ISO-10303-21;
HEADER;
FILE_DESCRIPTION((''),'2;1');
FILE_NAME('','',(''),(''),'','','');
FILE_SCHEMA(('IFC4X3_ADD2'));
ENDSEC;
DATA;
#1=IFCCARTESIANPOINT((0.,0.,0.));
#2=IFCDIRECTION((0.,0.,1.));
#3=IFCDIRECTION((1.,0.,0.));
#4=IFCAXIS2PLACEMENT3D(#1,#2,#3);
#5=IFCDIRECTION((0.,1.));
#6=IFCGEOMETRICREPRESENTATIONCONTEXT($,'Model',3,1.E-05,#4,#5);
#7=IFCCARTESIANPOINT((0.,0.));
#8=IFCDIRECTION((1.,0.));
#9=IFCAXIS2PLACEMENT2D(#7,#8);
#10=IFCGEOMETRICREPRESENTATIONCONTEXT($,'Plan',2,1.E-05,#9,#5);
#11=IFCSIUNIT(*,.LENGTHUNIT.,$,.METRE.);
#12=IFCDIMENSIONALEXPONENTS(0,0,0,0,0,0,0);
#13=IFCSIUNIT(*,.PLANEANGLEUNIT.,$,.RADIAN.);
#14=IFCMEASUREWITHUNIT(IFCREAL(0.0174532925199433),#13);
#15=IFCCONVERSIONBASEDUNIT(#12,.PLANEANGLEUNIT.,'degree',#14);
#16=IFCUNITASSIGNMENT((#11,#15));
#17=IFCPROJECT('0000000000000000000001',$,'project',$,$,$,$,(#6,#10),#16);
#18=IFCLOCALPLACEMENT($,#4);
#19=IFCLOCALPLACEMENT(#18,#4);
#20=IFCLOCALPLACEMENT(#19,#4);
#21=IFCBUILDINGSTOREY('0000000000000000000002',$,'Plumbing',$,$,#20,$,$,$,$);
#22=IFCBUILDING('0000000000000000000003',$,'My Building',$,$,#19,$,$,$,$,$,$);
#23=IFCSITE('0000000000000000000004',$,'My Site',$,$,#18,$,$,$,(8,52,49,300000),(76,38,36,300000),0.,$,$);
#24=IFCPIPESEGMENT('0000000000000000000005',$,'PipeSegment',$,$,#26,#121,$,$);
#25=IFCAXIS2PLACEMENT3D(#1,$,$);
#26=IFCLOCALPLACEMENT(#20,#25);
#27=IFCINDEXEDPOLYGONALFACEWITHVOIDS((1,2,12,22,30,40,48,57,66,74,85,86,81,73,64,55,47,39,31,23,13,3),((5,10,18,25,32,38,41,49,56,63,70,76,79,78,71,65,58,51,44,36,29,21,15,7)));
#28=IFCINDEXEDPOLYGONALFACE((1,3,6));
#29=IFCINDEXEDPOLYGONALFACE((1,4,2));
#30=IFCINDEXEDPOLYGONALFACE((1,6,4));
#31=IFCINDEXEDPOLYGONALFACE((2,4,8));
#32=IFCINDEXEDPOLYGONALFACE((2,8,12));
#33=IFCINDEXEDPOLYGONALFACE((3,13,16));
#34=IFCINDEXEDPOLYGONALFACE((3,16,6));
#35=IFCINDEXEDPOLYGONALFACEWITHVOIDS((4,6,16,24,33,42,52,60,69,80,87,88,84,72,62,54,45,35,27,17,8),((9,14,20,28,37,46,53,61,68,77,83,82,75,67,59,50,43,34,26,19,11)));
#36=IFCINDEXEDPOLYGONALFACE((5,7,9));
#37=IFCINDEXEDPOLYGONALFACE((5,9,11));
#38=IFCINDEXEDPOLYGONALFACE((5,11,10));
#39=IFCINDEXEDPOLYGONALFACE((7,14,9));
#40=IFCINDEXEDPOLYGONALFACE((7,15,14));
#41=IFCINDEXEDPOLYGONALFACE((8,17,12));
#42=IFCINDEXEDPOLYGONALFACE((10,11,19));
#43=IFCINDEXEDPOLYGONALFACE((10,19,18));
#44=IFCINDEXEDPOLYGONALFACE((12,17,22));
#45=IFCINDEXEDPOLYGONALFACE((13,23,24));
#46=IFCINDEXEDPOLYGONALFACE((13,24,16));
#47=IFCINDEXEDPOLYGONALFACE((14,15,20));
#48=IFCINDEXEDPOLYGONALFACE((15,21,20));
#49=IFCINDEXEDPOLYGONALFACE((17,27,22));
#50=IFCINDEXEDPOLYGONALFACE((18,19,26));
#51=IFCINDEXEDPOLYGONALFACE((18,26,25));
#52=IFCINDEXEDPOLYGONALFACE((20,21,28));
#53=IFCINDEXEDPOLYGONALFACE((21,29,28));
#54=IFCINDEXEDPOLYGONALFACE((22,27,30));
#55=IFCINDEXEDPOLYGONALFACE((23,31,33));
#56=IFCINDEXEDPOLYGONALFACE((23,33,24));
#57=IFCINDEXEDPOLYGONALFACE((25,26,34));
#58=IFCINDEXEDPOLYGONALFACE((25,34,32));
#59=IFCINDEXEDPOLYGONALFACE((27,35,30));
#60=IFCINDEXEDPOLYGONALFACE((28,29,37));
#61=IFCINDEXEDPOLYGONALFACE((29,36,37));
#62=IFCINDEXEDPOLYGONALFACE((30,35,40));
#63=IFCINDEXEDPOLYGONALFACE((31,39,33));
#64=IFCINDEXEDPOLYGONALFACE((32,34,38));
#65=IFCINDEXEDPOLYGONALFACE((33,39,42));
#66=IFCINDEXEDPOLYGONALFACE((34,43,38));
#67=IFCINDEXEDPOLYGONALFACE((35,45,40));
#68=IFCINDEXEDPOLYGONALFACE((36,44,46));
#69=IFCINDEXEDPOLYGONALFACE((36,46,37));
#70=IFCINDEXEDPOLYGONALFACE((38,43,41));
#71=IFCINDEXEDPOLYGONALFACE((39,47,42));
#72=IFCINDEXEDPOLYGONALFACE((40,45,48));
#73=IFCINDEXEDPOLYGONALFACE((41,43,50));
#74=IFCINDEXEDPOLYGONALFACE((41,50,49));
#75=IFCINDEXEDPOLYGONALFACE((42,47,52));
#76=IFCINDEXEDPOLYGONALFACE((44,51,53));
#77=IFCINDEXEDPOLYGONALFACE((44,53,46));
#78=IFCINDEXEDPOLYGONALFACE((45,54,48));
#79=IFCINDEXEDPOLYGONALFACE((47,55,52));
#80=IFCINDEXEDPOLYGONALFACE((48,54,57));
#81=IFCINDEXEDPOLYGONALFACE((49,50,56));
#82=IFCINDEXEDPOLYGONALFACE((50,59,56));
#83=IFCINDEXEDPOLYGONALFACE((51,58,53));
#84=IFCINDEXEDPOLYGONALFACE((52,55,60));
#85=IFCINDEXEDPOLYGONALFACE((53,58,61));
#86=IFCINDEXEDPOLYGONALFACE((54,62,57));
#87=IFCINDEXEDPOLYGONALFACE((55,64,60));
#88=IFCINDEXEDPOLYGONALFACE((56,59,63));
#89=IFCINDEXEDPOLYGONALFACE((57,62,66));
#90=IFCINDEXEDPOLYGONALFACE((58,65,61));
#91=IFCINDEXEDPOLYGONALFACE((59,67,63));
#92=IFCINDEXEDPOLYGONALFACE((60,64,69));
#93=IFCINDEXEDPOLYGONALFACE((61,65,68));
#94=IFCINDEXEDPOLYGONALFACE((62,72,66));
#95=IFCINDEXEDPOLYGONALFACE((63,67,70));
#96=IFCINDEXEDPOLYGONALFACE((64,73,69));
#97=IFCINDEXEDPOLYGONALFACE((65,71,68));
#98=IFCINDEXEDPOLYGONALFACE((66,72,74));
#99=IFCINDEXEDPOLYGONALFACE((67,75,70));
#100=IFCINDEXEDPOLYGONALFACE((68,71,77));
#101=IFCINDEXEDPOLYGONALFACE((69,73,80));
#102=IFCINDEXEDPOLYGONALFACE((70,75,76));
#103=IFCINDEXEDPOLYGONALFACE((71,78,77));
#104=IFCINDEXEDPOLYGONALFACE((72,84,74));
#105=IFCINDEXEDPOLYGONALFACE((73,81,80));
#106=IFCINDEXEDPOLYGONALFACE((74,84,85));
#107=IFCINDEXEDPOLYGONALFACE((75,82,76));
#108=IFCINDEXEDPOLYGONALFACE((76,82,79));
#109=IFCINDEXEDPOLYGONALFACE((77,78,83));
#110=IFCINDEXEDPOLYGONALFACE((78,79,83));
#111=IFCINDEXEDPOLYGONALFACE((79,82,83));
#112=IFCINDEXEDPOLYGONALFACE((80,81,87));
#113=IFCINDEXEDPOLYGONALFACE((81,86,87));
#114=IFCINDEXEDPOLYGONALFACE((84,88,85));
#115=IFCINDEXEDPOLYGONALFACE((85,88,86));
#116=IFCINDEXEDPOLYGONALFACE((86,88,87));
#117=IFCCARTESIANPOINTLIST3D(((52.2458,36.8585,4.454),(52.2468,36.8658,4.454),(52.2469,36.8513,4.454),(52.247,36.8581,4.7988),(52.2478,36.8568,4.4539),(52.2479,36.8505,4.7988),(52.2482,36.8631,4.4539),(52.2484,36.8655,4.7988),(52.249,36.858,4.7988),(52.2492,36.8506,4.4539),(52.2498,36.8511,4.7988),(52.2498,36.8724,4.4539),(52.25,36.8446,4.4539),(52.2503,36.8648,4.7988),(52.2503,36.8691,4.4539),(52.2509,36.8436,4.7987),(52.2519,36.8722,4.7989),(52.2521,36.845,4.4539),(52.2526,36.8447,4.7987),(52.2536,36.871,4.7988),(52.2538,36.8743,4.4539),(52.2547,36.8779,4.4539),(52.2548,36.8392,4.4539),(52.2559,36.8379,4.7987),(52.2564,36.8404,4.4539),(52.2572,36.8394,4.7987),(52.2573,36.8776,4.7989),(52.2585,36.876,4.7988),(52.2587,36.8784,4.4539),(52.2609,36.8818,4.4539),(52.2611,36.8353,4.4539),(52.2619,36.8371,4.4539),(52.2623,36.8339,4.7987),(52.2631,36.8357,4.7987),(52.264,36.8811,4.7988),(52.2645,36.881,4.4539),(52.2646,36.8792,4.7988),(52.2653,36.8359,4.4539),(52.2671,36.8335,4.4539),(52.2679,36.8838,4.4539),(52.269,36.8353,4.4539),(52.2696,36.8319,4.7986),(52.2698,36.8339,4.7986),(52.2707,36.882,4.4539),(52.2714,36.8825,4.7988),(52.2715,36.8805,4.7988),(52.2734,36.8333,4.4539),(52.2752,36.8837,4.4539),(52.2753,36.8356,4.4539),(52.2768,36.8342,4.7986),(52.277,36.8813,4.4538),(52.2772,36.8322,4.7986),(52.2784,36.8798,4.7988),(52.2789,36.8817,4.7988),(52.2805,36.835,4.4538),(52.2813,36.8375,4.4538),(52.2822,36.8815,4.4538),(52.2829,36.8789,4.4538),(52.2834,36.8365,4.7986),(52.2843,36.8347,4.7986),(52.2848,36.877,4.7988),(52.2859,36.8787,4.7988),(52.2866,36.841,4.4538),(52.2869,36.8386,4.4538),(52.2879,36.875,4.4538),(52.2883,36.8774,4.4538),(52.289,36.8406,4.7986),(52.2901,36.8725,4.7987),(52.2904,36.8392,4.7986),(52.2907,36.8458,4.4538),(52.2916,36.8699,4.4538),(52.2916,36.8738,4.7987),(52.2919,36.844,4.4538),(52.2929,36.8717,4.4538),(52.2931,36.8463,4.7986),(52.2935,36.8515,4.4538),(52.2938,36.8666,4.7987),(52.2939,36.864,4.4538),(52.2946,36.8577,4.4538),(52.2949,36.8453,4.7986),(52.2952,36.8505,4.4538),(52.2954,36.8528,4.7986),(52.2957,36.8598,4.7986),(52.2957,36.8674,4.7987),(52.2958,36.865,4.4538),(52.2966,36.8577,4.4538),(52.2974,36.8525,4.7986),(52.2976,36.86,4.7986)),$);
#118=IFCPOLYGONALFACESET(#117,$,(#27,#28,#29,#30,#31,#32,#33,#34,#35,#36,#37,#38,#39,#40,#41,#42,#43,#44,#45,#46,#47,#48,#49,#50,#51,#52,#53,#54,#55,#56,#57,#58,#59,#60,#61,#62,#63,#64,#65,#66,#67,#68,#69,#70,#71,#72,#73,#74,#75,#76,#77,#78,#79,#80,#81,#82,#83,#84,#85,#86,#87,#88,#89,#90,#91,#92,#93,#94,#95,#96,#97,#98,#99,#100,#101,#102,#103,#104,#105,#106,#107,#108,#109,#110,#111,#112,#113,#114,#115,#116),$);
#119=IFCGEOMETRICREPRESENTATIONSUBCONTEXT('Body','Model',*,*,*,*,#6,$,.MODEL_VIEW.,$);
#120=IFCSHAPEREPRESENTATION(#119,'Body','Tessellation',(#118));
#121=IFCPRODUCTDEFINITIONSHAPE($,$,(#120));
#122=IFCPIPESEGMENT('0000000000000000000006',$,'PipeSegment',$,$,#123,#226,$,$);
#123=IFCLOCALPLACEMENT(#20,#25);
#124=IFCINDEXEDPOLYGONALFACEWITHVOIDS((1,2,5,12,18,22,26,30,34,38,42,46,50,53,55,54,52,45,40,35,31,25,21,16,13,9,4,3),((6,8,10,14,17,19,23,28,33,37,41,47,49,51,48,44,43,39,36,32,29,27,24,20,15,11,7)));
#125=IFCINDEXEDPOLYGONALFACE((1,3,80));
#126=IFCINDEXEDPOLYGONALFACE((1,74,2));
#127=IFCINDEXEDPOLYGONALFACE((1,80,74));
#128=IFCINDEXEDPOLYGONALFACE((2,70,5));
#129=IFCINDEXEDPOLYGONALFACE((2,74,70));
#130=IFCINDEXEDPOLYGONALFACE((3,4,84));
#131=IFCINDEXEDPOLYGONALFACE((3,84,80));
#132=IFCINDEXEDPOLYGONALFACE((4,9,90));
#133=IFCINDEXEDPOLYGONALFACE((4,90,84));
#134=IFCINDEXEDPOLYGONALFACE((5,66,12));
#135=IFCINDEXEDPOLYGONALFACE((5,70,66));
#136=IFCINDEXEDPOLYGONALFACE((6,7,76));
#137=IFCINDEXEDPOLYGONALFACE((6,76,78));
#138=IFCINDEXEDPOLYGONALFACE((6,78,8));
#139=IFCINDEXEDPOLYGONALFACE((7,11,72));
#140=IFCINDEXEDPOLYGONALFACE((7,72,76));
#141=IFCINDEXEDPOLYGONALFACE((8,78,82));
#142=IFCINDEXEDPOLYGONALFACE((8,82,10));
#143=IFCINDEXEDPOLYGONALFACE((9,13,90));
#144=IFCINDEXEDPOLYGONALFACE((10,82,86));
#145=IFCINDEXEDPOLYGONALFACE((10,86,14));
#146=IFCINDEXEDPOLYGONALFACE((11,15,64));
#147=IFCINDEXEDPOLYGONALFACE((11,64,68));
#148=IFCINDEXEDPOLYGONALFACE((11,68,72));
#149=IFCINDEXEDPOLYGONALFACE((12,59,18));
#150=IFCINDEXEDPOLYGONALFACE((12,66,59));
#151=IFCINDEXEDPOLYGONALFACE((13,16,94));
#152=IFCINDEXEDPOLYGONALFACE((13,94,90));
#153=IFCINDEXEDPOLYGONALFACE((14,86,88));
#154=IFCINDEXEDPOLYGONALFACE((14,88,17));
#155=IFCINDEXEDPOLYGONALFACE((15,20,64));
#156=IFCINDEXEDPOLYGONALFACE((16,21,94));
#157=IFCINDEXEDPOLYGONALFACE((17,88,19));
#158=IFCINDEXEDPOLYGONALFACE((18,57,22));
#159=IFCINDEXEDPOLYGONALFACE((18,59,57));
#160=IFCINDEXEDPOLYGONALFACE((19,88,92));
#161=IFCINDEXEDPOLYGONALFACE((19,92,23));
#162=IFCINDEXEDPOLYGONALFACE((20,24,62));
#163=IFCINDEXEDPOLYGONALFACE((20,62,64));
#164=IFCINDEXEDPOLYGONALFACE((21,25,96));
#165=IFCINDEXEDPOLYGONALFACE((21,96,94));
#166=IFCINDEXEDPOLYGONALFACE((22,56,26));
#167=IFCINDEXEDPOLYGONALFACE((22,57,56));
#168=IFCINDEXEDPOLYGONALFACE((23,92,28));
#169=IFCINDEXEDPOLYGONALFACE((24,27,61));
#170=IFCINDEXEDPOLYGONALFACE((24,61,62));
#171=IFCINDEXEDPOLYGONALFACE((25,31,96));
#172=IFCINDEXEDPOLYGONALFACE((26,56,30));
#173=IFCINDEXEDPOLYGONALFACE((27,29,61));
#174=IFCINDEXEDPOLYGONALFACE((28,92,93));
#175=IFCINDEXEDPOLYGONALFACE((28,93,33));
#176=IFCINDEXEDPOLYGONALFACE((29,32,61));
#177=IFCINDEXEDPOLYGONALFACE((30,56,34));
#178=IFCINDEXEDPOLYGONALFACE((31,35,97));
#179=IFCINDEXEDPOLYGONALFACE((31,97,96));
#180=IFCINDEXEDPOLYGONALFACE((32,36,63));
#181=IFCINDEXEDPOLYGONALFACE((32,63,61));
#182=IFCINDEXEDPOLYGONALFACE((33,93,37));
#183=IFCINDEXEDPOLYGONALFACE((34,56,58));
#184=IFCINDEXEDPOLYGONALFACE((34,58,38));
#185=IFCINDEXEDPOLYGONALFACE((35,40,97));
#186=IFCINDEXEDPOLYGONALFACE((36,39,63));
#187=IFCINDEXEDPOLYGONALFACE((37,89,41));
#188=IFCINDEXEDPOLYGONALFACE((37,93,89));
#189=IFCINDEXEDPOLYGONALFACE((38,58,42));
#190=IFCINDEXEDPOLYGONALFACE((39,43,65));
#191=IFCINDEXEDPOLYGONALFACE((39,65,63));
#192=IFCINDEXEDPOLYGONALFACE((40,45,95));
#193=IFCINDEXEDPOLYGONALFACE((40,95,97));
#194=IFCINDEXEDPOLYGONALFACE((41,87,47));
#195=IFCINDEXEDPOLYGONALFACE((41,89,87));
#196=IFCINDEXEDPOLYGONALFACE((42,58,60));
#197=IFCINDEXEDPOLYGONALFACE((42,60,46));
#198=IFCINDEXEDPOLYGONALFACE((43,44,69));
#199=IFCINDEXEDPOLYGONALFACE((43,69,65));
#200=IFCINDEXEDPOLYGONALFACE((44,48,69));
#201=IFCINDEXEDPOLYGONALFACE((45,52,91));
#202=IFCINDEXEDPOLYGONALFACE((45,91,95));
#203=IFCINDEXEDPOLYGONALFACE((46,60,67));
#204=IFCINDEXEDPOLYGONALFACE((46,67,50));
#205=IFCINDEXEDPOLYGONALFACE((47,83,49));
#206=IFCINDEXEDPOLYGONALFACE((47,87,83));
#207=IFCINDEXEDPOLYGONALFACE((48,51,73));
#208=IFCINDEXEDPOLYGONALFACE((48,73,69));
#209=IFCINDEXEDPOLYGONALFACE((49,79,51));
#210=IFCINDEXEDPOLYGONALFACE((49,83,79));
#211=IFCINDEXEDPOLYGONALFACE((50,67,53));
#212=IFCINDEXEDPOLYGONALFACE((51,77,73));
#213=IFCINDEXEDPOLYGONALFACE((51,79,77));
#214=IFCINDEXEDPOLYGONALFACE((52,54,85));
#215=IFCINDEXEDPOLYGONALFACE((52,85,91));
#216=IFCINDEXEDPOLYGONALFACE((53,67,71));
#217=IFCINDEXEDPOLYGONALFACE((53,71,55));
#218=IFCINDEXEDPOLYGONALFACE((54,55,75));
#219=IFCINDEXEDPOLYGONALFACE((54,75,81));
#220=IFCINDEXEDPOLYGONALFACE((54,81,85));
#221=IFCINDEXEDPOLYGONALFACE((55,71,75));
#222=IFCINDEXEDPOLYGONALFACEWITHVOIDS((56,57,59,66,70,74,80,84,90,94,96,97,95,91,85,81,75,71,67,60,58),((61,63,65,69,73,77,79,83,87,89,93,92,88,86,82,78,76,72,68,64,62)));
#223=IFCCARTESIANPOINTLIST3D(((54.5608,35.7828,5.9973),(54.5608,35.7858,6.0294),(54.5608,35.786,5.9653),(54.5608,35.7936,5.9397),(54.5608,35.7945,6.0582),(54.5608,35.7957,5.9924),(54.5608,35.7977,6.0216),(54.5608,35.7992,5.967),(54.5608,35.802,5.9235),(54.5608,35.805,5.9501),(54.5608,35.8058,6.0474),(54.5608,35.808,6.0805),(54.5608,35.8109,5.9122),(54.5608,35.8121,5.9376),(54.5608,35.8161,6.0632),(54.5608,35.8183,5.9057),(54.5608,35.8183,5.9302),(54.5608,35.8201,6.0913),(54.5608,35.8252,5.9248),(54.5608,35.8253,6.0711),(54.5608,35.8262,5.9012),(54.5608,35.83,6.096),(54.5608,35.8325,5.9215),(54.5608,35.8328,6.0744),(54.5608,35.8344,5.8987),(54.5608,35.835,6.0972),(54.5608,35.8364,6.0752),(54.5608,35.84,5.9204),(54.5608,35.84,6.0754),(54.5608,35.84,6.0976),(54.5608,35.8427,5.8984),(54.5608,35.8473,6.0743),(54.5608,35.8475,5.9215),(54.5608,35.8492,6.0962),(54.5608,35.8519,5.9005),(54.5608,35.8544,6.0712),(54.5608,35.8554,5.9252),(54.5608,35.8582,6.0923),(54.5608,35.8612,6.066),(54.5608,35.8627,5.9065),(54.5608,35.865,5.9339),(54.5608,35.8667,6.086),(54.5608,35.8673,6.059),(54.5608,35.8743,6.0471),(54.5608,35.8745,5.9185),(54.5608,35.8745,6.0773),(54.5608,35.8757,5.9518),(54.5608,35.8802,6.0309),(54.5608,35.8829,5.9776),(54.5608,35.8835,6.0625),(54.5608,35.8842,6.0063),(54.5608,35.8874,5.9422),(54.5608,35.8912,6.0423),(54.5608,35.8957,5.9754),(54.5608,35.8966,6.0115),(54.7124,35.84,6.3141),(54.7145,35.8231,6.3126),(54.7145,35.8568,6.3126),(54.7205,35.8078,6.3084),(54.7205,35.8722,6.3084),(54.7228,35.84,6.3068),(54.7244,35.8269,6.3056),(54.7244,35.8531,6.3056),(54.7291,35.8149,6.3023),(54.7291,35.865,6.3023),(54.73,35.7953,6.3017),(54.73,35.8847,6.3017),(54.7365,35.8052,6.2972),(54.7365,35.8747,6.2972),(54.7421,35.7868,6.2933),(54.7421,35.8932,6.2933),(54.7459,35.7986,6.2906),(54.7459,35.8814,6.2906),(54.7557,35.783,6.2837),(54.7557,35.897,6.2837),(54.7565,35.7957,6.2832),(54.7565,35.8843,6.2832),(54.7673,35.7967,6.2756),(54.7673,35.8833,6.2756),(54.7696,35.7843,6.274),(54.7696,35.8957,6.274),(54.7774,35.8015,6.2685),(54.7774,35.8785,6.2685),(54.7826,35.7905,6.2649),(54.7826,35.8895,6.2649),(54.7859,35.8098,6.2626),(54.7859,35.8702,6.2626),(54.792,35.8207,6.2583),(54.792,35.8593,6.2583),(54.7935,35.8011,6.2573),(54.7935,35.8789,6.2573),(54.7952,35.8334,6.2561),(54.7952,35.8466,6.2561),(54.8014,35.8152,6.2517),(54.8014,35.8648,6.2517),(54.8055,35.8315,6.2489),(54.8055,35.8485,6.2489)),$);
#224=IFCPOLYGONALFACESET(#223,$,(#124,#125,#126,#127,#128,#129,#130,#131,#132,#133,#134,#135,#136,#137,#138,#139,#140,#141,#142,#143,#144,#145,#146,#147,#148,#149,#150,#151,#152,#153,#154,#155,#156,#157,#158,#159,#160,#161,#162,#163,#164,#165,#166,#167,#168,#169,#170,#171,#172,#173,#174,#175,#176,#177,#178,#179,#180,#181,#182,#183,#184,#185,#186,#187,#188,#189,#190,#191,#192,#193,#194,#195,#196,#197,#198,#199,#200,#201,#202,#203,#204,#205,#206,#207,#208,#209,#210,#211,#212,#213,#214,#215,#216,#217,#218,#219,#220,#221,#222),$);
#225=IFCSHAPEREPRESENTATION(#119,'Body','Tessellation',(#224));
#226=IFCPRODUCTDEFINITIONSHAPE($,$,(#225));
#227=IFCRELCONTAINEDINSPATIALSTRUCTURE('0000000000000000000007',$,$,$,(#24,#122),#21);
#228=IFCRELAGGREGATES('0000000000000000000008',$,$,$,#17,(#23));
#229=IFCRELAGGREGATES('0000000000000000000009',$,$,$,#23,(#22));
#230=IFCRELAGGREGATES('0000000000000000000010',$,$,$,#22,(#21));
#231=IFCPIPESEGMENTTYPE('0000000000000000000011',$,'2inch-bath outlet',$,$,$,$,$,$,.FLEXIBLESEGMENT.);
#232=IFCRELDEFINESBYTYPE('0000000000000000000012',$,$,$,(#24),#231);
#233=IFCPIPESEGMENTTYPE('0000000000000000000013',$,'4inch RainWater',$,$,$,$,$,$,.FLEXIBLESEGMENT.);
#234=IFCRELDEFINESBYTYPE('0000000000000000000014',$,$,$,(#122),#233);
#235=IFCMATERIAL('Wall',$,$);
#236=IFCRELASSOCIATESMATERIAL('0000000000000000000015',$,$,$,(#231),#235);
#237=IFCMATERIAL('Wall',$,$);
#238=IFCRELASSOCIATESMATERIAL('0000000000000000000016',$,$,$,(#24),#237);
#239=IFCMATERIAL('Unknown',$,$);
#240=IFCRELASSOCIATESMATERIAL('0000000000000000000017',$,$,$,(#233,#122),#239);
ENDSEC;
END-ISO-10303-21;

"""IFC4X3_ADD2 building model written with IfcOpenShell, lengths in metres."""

from ifc_helpers import new_model, entity, si_unit, converted_unit, direction, frame, origin_with_axes, origin_2d_with_axis, place, context, subcontext, project, spatial, hollow_circle, extrude, clip, halfspace, material, material_profile, profile_set, profile_usage, type_object, element, save


model = new_model("IFC4X3_ADD2")

# Units and contexts
model_context = context("Model", 3, precision=1e-05, world=origin_with_axes(), true_north=direction((0.0, 1.0)))
plan_context = context("Plan", 2, precision=1e-05, world=origin_2d_with_axis(), true_north=direction((0.0, 1.0)))
body_context_1 = subcontext(model_context, "Body", "Model", "MODEL_VIEW")
ifc_project = project(units=[si_unit("LENGTHUNIT", "METRE"), converted_unit("PLANEANGLEUNIT", "degree", entity("IfcReal", 0.0174532925199433), si_unit("PLANEANGLEUNIT", "RADIAN"), dimensions=[0, 0, 0, 0, 0, 0, 0])], contexts=[model_context, plan_context])

# Site, building, storey
site_placement = place(None, origin_with_axes())
site = spatial("IfcSite", under=ifc_project, at=site_placement, Name="My Site", RefLatitude=(8, 52, 49, 300000), RefLongitude=(76, 38, 36, 300000), RefElevation=0.0)
building_placement = place(site_placement, origin_with_axes())
building = spatial("IfcBuilding", under=site, at=building_placement, Name="My Building")
storey_placement = place(building_placement, origin_with_axes())
storey = spatial("IfcBuildingStorey", under=building, at=storey_placement, Name="Plumbing")

# Pipe segments
ifc_material_1 = material(Name="Wall")
ifc_material_profile_1 = material_profile(ifc_material_1, hollow_circle(Radius=0.0254, WallThickness=0.002))
ifc_profile_set_1 = profile_set([ifc_material_profile_1], Name="graywater")
ifc_material_2 = material(Name="Wall")
ifc_material_profile_2 = material_profile(ifc_material_2, hollow_circle(Radius=0.0254, WallThickness=0.002))
ifc_profile_set_2 = profile_set([ifc_material_profile_2], Name="graywater")
pipe_segment_type_1 = type_object("IfcPipeSegmentType", Name="2inch-bath outlet", PredefinedType="FLEXIBLESEGMENT", material=ifc_profile_set_2)
ifc_profile_usage_1 = profile_usage(ifc_profile_set_1, cardinal=5)
pipe_segment_1_placement = place(storey_placement, frame((52.271, 36.8588, 4.4031), z_axis=(0.003594, -0.004219, 0.999985), x_axis=(-0.398179, -0.917305, -0.002439)))
element("IfcPipeSegment", 1, at=pipe_segment_1_placement, inside=storey, type_object=pipe_segment_type_1, material=ifc_profile_usage_1, Name="PipeSegment", context=body_context_1, shape_type="Clipping", body=[
    clip(extrude(hollow_circle(Radius=0.0254, WallThickness=0.002), origin_with_axes(), (0.0, 0.0, 1.0), 0.3957), halfspace(frame((-0.0517, 0.12, 0.0508), z_axis=(0.003884, 0.001685, -0.999991), x_axis=(0.999992, 0.0, 0.003884)), False)),
])
ifc_material_3 = material(Name="Unknown")
ifc_material_profile_3 = material_profile(ifc_material_3, hollow_circle(Radius=0.0571, WallThickness=0.0127))
ifc_profile_set_3 = profile_set([ifc_material_profile_3], Name="rainwater")
ifc_profile_usage_2 = profile_usage(ifc_profile_set_3, cardinal=5)
pipe_segment_type_2 = type_object("IfcPipeSegmentType", Name="4inch RainWater", PredefinedType="FLEXIBLESEGMENT", material=ifc_profile_set_3)
pipe_segment_2_placement = place(storey_placement, frame((54.7592, 35.84, 6.2813), z_axis=(-0.573576, 0.0, -0.819152), x_axis=(-0.819152, 0.0, 0.573576)))
element("IfcPipeSegment", 2, at=pipe_segment_2_placement, inside=storey, type_object=pipe_segment_type_2, material=ifc_profile_usage_2, Name="PipeSegment", context=body_context_1, shape_type="Clipping", body=[
    clip(extrude(hollow_circle(Radius=0.0571, WallThickness=0.0127), origin_with_axes(), (0.0, 0.0, 1.0), 0.4602), halfspace(frame((0.0759, 0.0, 0.2375), z_axis=(0.819152, 0.0, 0.573576), x_axis=(0.0, -1.0, 0.0)), False)),
])

save(model, "model.ifc")
